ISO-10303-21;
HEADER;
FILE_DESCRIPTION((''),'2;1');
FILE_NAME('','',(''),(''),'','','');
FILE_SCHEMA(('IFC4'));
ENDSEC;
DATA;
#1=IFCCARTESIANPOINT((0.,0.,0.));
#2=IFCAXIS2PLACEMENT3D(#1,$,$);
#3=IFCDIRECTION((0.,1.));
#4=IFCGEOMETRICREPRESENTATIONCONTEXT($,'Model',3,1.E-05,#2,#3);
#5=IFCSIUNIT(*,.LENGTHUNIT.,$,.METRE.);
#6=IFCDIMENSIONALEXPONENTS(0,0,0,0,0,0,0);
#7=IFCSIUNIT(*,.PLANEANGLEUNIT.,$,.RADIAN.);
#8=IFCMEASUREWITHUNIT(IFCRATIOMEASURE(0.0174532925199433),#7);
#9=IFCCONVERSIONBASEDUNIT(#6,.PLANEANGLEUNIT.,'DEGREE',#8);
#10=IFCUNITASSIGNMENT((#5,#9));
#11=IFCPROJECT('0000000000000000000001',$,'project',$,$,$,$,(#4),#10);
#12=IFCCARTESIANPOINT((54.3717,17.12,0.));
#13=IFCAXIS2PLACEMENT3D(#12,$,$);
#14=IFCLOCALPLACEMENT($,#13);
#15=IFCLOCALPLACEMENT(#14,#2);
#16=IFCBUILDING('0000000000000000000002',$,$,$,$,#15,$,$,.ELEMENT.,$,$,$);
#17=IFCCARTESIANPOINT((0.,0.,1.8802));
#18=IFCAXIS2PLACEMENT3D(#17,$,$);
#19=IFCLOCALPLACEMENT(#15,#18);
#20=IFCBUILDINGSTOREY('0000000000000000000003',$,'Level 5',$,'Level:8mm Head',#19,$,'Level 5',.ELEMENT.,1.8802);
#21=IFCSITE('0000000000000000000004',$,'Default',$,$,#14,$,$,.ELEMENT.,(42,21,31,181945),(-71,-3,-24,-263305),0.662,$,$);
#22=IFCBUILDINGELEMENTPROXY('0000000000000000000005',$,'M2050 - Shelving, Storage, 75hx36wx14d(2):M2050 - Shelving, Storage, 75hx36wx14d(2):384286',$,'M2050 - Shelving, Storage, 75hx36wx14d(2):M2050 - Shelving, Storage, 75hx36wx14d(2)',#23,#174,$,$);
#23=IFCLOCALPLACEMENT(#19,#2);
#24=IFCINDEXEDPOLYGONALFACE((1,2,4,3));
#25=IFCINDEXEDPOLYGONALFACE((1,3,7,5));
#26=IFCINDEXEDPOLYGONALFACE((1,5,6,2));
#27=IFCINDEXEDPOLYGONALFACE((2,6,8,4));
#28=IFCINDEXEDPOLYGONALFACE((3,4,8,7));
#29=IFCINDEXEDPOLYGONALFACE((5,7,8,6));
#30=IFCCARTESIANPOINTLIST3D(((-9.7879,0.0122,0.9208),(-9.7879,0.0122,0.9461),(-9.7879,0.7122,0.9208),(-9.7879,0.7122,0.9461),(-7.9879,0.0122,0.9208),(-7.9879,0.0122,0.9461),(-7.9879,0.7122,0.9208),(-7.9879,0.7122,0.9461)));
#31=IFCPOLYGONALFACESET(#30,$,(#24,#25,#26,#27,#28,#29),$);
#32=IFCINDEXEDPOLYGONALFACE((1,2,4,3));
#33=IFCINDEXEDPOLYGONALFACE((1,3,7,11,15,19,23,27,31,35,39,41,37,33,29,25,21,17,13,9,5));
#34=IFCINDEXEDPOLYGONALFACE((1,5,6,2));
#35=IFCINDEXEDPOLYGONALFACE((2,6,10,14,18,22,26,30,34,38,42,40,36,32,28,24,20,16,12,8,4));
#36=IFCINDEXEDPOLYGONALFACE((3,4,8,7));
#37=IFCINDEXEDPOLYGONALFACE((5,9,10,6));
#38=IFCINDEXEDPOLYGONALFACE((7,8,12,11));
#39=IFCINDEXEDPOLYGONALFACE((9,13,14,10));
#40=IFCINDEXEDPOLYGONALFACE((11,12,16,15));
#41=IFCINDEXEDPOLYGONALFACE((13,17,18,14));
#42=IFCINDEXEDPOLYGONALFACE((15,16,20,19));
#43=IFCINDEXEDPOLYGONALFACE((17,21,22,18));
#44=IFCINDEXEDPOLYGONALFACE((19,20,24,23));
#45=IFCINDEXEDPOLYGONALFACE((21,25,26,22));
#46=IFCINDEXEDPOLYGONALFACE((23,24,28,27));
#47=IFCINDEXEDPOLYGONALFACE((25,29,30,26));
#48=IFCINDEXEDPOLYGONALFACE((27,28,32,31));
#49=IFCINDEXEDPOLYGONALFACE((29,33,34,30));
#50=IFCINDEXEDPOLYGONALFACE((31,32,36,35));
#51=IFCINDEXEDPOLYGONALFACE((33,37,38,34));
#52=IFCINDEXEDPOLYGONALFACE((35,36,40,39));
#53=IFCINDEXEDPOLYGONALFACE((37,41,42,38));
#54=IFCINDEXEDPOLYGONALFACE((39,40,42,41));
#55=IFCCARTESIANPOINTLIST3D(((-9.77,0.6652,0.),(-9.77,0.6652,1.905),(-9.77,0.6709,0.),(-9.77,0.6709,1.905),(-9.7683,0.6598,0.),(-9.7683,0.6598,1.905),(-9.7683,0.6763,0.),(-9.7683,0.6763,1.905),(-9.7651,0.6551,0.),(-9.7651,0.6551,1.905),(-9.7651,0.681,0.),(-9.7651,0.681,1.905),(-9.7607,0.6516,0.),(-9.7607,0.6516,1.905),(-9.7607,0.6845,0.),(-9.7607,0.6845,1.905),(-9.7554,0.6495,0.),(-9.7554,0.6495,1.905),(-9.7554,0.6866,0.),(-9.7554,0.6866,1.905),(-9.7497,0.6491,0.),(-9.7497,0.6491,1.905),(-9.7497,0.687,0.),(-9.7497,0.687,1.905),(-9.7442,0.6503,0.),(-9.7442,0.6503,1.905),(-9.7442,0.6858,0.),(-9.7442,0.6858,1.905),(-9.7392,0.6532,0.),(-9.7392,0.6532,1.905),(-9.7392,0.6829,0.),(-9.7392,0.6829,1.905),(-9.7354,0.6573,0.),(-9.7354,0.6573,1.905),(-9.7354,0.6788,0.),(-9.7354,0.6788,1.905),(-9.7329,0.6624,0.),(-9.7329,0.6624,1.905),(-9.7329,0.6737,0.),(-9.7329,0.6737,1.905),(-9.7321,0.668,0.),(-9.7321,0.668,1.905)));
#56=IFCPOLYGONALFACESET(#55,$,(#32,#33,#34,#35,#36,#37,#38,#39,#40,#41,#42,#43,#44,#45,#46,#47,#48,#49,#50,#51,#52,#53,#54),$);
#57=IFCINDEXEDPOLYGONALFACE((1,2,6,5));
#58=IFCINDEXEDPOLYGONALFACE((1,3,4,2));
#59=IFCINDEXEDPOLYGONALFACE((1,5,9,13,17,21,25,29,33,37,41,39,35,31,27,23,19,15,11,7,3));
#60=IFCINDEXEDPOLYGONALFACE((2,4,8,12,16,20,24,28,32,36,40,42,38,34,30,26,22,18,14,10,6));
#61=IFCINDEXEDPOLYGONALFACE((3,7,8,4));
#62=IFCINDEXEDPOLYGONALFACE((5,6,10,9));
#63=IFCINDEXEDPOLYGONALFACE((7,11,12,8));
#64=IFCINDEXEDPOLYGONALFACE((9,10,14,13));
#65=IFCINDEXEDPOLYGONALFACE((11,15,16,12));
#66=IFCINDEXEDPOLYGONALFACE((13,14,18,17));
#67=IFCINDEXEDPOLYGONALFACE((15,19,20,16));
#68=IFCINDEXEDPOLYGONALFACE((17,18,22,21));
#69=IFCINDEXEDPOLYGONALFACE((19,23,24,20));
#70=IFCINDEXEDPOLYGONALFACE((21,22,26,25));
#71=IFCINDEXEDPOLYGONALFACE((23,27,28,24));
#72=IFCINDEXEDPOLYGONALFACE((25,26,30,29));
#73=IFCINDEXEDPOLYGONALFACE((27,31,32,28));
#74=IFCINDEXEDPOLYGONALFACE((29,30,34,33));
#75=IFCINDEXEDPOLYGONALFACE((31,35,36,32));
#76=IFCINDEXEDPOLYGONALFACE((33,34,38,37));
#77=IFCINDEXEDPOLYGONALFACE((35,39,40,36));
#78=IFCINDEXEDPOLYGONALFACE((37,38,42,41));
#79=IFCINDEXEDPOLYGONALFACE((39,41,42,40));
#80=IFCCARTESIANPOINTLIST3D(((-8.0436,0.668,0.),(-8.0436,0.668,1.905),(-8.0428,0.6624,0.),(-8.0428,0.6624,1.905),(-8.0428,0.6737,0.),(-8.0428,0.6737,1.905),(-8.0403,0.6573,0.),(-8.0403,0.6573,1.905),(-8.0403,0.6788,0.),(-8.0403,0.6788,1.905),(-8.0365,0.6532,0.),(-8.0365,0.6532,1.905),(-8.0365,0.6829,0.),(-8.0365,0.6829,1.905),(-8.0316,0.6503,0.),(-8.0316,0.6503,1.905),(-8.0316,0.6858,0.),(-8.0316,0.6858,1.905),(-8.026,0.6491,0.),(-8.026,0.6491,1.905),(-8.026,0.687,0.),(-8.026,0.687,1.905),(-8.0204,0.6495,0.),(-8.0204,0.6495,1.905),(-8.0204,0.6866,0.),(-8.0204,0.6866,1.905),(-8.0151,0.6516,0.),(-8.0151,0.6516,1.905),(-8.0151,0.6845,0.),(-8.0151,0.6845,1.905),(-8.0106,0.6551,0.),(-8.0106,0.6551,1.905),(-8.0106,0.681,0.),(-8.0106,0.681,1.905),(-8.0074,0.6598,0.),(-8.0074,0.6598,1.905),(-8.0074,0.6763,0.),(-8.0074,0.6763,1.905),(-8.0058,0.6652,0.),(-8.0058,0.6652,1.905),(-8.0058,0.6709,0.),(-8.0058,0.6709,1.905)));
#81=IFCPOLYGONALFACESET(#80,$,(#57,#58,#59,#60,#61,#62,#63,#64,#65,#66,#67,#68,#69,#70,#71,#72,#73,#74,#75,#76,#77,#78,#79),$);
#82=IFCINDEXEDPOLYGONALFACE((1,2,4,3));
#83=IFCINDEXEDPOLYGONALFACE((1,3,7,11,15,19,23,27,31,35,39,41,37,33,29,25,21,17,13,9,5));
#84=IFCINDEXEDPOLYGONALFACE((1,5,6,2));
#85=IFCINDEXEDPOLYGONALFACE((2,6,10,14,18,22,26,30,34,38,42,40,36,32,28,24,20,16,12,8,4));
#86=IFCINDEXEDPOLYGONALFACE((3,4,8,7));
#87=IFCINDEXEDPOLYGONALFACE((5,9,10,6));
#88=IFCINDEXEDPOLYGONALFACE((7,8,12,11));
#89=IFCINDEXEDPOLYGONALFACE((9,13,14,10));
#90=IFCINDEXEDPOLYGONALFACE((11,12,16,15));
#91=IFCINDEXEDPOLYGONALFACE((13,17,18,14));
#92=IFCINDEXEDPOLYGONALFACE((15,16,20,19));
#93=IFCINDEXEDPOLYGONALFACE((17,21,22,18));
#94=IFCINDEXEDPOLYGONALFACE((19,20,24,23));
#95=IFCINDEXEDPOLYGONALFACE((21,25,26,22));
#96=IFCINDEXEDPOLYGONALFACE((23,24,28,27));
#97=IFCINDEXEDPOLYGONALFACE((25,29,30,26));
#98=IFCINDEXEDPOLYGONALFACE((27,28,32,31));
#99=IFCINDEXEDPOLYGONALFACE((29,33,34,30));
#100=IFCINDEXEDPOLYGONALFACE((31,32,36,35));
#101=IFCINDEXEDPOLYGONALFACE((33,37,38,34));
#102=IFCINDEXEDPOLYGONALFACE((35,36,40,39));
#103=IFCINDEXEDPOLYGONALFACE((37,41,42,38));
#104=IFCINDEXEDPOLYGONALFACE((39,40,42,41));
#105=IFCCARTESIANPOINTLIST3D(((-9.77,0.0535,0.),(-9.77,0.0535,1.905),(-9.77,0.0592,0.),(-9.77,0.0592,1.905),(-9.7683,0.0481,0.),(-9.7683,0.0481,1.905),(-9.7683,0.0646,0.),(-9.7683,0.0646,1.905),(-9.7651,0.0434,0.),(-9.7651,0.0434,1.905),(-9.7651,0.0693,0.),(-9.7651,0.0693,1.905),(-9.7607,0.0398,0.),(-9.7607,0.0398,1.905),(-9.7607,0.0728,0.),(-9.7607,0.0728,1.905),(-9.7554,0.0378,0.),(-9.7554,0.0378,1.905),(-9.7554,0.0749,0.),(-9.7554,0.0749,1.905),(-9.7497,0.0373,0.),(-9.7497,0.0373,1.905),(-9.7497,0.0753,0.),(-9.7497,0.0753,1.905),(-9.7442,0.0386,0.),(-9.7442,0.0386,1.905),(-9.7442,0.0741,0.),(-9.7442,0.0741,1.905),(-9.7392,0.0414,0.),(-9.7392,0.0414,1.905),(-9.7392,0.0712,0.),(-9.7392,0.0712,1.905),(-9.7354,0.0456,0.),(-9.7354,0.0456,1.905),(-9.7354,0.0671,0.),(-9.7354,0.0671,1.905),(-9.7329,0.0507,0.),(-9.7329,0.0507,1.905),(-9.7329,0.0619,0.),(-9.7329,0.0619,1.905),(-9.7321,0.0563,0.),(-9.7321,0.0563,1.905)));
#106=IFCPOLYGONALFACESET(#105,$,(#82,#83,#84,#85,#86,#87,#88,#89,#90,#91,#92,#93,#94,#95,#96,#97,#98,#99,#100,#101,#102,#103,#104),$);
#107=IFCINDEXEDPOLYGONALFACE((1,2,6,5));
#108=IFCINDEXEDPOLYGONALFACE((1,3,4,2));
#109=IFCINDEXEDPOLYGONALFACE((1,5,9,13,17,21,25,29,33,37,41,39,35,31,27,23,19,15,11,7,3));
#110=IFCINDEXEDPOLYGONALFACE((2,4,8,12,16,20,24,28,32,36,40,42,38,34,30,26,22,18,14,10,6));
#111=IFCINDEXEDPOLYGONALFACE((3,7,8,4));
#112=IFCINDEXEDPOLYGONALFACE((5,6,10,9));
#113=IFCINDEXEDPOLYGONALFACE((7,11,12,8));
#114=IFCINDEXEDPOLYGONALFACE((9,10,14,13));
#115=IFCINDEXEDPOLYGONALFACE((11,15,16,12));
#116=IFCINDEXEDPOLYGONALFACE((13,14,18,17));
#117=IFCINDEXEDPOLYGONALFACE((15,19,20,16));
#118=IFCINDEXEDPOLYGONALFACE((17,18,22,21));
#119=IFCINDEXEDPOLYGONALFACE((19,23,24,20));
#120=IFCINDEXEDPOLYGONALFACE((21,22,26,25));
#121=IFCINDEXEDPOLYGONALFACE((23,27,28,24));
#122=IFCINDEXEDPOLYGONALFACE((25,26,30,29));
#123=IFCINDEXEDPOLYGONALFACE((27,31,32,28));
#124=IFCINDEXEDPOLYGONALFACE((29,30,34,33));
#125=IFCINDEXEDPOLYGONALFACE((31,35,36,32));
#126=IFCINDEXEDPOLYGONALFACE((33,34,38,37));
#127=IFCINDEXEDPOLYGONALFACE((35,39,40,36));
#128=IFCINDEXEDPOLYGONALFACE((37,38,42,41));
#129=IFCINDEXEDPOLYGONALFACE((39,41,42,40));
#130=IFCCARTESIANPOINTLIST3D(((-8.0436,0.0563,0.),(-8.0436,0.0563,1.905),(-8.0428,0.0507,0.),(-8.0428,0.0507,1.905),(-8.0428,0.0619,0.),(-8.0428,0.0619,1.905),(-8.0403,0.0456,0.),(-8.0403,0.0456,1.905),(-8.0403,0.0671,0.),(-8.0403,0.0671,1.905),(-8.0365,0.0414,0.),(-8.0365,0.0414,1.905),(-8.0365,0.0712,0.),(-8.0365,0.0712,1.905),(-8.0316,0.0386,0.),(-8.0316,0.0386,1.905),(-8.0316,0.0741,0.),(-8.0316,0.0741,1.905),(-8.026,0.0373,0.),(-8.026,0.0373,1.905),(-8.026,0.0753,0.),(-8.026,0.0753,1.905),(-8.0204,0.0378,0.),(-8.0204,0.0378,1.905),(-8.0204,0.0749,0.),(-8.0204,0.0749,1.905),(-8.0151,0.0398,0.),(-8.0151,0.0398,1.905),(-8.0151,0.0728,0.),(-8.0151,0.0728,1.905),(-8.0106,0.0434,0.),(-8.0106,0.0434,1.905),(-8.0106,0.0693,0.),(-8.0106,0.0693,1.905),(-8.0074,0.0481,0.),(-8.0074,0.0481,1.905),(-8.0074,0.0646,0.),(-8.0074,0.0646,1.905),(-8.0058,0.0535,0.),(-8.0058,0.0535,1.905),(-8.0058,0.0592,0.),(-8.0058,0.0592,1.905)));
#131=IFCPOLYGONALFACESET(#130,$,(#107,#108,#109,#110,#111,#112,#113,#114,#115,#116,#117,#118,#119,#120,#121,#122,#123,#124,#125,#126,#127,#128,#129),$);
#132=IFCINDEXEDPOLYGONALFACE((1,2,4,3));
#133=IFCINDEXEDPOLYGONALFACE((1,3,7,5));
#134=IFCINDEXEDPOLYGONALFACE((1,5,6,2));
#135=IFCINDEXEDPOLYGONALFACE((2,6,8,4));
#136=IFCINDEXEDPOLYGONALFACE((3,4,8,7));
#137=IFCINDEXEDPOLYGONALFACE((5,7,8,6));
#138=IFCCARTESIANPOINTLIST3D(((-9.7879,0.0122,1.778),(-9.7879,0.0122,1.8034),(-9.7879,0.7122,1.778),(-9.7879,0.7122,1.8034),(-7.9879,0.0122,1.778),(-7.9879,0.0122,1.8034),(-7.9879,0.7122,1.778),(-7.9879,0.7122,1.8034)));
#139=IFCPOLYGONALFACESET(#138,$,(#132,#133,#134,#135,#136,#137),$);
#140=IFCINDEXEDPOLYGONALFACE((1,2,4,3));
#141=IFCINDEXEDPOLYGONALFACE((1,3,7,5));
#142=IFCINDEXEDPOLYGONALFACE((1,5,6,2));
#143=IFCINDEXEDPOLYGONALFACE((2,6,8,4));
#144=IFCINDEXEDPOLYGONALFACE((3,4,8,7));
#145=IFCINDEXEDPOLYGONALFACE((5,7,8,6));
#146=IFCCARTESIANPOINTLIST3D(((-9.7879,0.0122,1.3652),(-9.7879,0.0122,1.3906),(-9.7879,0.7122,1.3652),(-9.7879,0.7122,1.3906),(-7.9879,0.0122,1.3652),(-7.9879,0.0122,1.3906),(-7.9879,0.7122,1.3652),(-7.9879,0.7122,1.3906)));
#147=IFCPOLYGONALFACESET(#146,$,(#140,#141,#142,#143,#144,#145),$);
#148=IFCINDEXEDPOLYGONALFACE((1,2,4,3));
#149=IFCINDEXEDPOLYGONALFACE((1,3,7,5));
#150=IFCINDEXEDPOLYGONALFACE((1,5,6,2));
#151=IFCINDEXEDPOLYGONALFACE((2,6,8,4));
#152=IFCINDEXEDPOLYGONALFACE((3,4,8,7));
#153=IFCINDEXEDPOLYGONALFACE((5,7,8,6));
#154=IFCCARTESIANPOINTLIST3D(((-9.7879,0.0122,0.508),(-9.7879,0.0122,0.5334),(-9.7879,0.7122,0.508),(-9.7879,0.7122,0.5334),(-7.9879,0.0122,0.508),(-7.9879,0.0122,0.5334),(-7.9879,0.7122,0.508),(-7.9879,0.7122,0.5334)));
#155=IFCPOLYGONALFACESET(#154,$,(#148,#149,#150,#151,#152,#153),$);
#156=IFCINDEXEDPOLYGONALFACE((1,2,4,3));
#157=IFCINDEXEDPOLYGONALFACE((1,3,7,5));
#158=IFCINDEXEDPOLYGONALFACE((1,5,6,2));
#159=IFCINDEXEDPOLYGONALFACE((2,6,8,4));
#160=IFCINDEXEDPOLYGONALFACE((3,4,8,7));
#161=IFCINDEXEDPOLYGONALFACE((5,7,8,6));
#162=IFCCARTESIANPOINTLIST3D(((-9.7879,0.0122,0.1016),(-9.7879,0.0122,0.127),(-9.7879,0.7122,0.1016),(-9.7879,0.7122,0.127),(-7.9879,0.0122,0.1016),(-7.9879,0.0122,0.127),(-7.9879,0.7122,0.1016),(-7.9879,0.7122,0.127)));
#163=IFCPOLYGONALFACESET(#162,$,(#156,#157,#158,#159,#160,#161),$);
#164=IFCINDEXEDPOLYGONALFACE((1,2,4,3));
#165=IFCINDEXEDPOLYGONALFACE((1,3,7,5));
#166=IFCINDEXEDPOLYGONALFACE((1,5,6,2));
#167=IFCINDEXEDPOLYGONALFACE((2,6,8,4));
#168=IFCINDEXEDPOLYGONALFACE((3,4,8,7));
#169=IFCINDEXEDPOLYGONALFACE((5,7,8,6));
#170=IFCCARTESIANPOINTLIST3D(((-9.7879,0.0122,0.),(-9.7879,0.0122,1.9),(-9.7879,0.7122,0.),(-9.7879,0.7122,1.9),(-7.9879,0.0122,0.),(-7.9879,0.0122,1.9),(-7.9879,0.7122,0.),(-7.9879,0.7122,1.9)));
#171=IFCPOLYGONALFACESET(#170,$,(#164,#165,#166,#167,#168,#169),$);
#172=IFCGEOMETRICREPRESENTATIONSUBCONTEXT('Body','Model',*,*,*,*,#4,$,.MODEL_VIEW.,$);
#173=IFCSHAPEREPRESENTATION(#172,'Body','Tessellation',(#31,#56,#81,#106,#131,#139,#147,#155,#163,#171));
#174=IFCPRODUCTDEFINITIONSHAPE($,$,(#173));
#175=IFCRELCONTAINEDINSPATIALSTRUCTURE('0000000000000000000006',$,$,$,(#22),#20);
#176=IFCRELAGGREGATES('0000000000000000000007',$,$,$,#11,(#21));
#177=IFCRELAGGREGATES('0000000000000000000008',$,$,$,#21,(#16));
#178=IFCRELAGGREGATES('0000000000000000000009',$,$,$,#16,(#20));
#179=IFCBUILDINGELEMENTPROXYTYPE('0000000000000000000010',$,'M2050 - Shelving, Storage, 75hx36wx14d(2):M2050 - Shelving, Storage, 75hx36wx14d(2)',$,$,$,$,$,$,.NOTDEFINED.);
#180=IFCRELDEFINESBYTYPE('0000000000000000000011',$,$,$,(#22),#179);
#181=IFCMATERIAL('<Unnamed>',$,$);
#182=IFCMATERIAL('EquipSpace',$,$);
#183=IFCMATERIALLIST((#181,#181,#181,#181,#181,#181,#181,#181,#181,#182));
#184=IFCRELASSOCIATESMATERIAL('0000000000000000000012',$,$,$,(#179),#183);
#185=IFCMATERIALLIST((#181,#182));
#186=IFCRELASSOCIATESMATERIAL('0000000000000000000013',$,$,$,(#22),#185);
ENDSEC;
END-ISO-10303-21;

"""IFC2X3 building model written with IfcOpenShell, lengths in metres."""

from ifc_helpers import new_model, entity, si_unit, converted_unit, direction, frame, frame_2d, origin, origin_2d_with_axis, place, context, subcontext, project, spatial, rectangle, circle, extrude, source, transform, mapped, material, material_list, type_object, type_shapes, element, save


model = new_model("IFC2X3")

# Units and contexts
model_context = context("Model", 3, precision=1e-05, world=origin(), true_north=direction((0.0, 1.0)))
body_context = subcontext(model_context, "Body", "Model", "MODEL_VIEW")
ifc_project = project(units=[si_unit("LENGTHUNIT", "METRE"), converted_unit("PLANEANGLEUNIT", "DEGREE", entity("IfcRatioMeasure", 0.0174532925199433), si_unit("PLANEANGLEUNIT", "RADIAN"), dimensions=[0, 0, 0, 0, 0, 0, 0])], contexts=[model_context])

# Site, building, storey
site_placement = place(None, frame((54.3717, 17.12, 0.0)))
site = spatial("IfcSite", under=ifc_project, at=site_placement, Name="Default", CompositionType="ELEMENT", RefLatitude=(42, 21, 31, 181945), RefLongitude=(-71, -3, -24, -263305), RefElevation=0.662)
building_placement = place(site_placement, origin())
building = spatial("IfcBuilding", under=site, at=building_placement, CompositionType="ELEMENT")
storey_placement = place(building_placement, frame((0.0, 0.0, 1.8802)))
storey = spatial("IfcBuildingStorey", under=building, at=storey_placement, Name="Level 5", ObjectType="Level:8mm Head", LongName="Level 5", CompositionType="ELEMENT", Elevation=1.8802)

# Building element proxy
ifc_material_1 = material(Name="<Unnamed>")
ifc_material_2 = material(Name="EquipSpace")
ifc_material_list_1 = material_list([ifc_material_1, ifc_material_1, ifc_material_1, ifc_material_1, ifc_material_1, ifc_material_1, ifc_material_1, ifc_material_1, ifc_material_1, ifc_material_2])
building_element_proxy_type = type_object("IfcBuildingElementProxyType", Name="M2050 - Shelving, Storage, 75hx36wx14d(2):M2050 - Shelving, Storage, 75hx36wx14d(2)", PredefinedType="NOTDEFINED", material=ifc_material_list_1)
shared_shape = source(origin(), body_context, "Body", "SweptSolid", [
    extrude(rectangle(XDim=1.8, YDim=0.7, at=origin_2d_with_axis()), frame((0.0, 0.0, 0.9207), z_axis=(0.0, 0.0, 1.0), x_axis=(-1.0, 0.0, 0.0)), (0.0, 0.0, 1.0), 0.0254),
    extrude(circle(Radius=0.0191, at=origin_2d_with_axis()), frame((0.8633, -0.3059, 0.0), z_axis=(0.0, 0.0, 1.0), x_axis=(-1.0, 0.0, 0.0)), (0.0, 0.0, 1.0), 1.905),
    extrude(circle(Radius=0.0191, at=origin_2d_with_axis()), frame((-0.8633, -0.3059, 0.0)), (0.0, 0.0, 1.0), 1.905),
    extrude(circle(Radius=0.0191, at=origin_2d_with_axis()), frame((0.8633, 0.3059, 0.0), z_axis=(0.0, 0.0, 1.0), x_axis=(-1.0, 0.0, 0.0)), (0.0, 0.0, 1.0), 1.905),
    extrude(circle(Radius=0.0191, at=origin_2d_with_axis()), frame((-0.8633, 0.3059, 0.0)), (0.0, 0.0, 1.0), 1.905),
    extrude(rectangle(XDim=1.8, YDim=0.7, at=origin_2d_with_axis()), frame((0.0, 0.0, 1.778), z_axis=(0.0, 0.0, 1.0), x_axis=(-1.0, 0.0, 0.0)), (0.0, 0.0, 1.0), 0.0254),
    extrude(rectangle(XDim=1.8, YDim=0.7, at=origin_2d_with_axis()), frame((0.0, 0.0, 1.3653), z_axis=(0.0, 0.0, 1.0), x_axis=(-1.0, 0.0, 0.0)), (0.0, 0.0, 1.0), 0.0254),
    extrude(rectangle(XDim=1.8, YDim=0.7, at=origin_2d_with_axis()), frame((0.0, 0.0, 0.508), z_axis=(0.0, 0.0, 1.0), x_axis=(-1.0, 0.0, 0.0)), (0.0, 0.0, 1.0), 0.0254),
    extrude(rectangle(XDim=1.8, YDim=0.7, at=origin_2d_with_axis()), frame((0.0, 0.0, 0.1016), z_axis=(0.0, 0.0, 1.0), x_axis=(-1.0, 0.0, 0.0)), (0.0, 0.0, 1.0), 0.0254),
    extrude(rectangle(XDim=0.7, YDim=1.8, at=frame_2d((0.0, 0.18), x_axis=(1.0, 0.0))), frame((-0.18, 0.0, 0.0), z_axis=(0.0, 0.0, 1.0), x_axis=(0.0, -1.0, 0.0)), (0.0, 0.0, 1.0), 1.9),
])
type_shapes(building_element_proxy_type, [shared_shape])
ifc_material_list_2 = material_list([ifc_material_1, ifc_material_2])
proxy_1_placement = place(storey_placement, frame((-8.8879, 0.3622, 0.0), z_axis=(0.0, 0.0, 1.0), x_axis=(-1.0, 0.0, 0.0)))
element("IfcBuildingElementProxy", 1, at=proxy_1_placement, inside=storey, type_object=building_element_proxy_type, material=ifc_material_list_2, Name="M2050 - Shelving, Storage, 75hx36wx14d(2):M2050 - Shelving, Storage, 75hx36wx14d(2):384286", ObjectType="M2050 - Shelving, Storage, 75hx36wx14d(2):M2050 - Shelving, Storage, 75hx36wx14d(2)", context=body_context, shape_type="MappedRepresentation", body=[
    mapped(shared_shape, transform((0.0, 0.0, 0.0), scale=1.0)),
])

save(model, "model.ifc")
